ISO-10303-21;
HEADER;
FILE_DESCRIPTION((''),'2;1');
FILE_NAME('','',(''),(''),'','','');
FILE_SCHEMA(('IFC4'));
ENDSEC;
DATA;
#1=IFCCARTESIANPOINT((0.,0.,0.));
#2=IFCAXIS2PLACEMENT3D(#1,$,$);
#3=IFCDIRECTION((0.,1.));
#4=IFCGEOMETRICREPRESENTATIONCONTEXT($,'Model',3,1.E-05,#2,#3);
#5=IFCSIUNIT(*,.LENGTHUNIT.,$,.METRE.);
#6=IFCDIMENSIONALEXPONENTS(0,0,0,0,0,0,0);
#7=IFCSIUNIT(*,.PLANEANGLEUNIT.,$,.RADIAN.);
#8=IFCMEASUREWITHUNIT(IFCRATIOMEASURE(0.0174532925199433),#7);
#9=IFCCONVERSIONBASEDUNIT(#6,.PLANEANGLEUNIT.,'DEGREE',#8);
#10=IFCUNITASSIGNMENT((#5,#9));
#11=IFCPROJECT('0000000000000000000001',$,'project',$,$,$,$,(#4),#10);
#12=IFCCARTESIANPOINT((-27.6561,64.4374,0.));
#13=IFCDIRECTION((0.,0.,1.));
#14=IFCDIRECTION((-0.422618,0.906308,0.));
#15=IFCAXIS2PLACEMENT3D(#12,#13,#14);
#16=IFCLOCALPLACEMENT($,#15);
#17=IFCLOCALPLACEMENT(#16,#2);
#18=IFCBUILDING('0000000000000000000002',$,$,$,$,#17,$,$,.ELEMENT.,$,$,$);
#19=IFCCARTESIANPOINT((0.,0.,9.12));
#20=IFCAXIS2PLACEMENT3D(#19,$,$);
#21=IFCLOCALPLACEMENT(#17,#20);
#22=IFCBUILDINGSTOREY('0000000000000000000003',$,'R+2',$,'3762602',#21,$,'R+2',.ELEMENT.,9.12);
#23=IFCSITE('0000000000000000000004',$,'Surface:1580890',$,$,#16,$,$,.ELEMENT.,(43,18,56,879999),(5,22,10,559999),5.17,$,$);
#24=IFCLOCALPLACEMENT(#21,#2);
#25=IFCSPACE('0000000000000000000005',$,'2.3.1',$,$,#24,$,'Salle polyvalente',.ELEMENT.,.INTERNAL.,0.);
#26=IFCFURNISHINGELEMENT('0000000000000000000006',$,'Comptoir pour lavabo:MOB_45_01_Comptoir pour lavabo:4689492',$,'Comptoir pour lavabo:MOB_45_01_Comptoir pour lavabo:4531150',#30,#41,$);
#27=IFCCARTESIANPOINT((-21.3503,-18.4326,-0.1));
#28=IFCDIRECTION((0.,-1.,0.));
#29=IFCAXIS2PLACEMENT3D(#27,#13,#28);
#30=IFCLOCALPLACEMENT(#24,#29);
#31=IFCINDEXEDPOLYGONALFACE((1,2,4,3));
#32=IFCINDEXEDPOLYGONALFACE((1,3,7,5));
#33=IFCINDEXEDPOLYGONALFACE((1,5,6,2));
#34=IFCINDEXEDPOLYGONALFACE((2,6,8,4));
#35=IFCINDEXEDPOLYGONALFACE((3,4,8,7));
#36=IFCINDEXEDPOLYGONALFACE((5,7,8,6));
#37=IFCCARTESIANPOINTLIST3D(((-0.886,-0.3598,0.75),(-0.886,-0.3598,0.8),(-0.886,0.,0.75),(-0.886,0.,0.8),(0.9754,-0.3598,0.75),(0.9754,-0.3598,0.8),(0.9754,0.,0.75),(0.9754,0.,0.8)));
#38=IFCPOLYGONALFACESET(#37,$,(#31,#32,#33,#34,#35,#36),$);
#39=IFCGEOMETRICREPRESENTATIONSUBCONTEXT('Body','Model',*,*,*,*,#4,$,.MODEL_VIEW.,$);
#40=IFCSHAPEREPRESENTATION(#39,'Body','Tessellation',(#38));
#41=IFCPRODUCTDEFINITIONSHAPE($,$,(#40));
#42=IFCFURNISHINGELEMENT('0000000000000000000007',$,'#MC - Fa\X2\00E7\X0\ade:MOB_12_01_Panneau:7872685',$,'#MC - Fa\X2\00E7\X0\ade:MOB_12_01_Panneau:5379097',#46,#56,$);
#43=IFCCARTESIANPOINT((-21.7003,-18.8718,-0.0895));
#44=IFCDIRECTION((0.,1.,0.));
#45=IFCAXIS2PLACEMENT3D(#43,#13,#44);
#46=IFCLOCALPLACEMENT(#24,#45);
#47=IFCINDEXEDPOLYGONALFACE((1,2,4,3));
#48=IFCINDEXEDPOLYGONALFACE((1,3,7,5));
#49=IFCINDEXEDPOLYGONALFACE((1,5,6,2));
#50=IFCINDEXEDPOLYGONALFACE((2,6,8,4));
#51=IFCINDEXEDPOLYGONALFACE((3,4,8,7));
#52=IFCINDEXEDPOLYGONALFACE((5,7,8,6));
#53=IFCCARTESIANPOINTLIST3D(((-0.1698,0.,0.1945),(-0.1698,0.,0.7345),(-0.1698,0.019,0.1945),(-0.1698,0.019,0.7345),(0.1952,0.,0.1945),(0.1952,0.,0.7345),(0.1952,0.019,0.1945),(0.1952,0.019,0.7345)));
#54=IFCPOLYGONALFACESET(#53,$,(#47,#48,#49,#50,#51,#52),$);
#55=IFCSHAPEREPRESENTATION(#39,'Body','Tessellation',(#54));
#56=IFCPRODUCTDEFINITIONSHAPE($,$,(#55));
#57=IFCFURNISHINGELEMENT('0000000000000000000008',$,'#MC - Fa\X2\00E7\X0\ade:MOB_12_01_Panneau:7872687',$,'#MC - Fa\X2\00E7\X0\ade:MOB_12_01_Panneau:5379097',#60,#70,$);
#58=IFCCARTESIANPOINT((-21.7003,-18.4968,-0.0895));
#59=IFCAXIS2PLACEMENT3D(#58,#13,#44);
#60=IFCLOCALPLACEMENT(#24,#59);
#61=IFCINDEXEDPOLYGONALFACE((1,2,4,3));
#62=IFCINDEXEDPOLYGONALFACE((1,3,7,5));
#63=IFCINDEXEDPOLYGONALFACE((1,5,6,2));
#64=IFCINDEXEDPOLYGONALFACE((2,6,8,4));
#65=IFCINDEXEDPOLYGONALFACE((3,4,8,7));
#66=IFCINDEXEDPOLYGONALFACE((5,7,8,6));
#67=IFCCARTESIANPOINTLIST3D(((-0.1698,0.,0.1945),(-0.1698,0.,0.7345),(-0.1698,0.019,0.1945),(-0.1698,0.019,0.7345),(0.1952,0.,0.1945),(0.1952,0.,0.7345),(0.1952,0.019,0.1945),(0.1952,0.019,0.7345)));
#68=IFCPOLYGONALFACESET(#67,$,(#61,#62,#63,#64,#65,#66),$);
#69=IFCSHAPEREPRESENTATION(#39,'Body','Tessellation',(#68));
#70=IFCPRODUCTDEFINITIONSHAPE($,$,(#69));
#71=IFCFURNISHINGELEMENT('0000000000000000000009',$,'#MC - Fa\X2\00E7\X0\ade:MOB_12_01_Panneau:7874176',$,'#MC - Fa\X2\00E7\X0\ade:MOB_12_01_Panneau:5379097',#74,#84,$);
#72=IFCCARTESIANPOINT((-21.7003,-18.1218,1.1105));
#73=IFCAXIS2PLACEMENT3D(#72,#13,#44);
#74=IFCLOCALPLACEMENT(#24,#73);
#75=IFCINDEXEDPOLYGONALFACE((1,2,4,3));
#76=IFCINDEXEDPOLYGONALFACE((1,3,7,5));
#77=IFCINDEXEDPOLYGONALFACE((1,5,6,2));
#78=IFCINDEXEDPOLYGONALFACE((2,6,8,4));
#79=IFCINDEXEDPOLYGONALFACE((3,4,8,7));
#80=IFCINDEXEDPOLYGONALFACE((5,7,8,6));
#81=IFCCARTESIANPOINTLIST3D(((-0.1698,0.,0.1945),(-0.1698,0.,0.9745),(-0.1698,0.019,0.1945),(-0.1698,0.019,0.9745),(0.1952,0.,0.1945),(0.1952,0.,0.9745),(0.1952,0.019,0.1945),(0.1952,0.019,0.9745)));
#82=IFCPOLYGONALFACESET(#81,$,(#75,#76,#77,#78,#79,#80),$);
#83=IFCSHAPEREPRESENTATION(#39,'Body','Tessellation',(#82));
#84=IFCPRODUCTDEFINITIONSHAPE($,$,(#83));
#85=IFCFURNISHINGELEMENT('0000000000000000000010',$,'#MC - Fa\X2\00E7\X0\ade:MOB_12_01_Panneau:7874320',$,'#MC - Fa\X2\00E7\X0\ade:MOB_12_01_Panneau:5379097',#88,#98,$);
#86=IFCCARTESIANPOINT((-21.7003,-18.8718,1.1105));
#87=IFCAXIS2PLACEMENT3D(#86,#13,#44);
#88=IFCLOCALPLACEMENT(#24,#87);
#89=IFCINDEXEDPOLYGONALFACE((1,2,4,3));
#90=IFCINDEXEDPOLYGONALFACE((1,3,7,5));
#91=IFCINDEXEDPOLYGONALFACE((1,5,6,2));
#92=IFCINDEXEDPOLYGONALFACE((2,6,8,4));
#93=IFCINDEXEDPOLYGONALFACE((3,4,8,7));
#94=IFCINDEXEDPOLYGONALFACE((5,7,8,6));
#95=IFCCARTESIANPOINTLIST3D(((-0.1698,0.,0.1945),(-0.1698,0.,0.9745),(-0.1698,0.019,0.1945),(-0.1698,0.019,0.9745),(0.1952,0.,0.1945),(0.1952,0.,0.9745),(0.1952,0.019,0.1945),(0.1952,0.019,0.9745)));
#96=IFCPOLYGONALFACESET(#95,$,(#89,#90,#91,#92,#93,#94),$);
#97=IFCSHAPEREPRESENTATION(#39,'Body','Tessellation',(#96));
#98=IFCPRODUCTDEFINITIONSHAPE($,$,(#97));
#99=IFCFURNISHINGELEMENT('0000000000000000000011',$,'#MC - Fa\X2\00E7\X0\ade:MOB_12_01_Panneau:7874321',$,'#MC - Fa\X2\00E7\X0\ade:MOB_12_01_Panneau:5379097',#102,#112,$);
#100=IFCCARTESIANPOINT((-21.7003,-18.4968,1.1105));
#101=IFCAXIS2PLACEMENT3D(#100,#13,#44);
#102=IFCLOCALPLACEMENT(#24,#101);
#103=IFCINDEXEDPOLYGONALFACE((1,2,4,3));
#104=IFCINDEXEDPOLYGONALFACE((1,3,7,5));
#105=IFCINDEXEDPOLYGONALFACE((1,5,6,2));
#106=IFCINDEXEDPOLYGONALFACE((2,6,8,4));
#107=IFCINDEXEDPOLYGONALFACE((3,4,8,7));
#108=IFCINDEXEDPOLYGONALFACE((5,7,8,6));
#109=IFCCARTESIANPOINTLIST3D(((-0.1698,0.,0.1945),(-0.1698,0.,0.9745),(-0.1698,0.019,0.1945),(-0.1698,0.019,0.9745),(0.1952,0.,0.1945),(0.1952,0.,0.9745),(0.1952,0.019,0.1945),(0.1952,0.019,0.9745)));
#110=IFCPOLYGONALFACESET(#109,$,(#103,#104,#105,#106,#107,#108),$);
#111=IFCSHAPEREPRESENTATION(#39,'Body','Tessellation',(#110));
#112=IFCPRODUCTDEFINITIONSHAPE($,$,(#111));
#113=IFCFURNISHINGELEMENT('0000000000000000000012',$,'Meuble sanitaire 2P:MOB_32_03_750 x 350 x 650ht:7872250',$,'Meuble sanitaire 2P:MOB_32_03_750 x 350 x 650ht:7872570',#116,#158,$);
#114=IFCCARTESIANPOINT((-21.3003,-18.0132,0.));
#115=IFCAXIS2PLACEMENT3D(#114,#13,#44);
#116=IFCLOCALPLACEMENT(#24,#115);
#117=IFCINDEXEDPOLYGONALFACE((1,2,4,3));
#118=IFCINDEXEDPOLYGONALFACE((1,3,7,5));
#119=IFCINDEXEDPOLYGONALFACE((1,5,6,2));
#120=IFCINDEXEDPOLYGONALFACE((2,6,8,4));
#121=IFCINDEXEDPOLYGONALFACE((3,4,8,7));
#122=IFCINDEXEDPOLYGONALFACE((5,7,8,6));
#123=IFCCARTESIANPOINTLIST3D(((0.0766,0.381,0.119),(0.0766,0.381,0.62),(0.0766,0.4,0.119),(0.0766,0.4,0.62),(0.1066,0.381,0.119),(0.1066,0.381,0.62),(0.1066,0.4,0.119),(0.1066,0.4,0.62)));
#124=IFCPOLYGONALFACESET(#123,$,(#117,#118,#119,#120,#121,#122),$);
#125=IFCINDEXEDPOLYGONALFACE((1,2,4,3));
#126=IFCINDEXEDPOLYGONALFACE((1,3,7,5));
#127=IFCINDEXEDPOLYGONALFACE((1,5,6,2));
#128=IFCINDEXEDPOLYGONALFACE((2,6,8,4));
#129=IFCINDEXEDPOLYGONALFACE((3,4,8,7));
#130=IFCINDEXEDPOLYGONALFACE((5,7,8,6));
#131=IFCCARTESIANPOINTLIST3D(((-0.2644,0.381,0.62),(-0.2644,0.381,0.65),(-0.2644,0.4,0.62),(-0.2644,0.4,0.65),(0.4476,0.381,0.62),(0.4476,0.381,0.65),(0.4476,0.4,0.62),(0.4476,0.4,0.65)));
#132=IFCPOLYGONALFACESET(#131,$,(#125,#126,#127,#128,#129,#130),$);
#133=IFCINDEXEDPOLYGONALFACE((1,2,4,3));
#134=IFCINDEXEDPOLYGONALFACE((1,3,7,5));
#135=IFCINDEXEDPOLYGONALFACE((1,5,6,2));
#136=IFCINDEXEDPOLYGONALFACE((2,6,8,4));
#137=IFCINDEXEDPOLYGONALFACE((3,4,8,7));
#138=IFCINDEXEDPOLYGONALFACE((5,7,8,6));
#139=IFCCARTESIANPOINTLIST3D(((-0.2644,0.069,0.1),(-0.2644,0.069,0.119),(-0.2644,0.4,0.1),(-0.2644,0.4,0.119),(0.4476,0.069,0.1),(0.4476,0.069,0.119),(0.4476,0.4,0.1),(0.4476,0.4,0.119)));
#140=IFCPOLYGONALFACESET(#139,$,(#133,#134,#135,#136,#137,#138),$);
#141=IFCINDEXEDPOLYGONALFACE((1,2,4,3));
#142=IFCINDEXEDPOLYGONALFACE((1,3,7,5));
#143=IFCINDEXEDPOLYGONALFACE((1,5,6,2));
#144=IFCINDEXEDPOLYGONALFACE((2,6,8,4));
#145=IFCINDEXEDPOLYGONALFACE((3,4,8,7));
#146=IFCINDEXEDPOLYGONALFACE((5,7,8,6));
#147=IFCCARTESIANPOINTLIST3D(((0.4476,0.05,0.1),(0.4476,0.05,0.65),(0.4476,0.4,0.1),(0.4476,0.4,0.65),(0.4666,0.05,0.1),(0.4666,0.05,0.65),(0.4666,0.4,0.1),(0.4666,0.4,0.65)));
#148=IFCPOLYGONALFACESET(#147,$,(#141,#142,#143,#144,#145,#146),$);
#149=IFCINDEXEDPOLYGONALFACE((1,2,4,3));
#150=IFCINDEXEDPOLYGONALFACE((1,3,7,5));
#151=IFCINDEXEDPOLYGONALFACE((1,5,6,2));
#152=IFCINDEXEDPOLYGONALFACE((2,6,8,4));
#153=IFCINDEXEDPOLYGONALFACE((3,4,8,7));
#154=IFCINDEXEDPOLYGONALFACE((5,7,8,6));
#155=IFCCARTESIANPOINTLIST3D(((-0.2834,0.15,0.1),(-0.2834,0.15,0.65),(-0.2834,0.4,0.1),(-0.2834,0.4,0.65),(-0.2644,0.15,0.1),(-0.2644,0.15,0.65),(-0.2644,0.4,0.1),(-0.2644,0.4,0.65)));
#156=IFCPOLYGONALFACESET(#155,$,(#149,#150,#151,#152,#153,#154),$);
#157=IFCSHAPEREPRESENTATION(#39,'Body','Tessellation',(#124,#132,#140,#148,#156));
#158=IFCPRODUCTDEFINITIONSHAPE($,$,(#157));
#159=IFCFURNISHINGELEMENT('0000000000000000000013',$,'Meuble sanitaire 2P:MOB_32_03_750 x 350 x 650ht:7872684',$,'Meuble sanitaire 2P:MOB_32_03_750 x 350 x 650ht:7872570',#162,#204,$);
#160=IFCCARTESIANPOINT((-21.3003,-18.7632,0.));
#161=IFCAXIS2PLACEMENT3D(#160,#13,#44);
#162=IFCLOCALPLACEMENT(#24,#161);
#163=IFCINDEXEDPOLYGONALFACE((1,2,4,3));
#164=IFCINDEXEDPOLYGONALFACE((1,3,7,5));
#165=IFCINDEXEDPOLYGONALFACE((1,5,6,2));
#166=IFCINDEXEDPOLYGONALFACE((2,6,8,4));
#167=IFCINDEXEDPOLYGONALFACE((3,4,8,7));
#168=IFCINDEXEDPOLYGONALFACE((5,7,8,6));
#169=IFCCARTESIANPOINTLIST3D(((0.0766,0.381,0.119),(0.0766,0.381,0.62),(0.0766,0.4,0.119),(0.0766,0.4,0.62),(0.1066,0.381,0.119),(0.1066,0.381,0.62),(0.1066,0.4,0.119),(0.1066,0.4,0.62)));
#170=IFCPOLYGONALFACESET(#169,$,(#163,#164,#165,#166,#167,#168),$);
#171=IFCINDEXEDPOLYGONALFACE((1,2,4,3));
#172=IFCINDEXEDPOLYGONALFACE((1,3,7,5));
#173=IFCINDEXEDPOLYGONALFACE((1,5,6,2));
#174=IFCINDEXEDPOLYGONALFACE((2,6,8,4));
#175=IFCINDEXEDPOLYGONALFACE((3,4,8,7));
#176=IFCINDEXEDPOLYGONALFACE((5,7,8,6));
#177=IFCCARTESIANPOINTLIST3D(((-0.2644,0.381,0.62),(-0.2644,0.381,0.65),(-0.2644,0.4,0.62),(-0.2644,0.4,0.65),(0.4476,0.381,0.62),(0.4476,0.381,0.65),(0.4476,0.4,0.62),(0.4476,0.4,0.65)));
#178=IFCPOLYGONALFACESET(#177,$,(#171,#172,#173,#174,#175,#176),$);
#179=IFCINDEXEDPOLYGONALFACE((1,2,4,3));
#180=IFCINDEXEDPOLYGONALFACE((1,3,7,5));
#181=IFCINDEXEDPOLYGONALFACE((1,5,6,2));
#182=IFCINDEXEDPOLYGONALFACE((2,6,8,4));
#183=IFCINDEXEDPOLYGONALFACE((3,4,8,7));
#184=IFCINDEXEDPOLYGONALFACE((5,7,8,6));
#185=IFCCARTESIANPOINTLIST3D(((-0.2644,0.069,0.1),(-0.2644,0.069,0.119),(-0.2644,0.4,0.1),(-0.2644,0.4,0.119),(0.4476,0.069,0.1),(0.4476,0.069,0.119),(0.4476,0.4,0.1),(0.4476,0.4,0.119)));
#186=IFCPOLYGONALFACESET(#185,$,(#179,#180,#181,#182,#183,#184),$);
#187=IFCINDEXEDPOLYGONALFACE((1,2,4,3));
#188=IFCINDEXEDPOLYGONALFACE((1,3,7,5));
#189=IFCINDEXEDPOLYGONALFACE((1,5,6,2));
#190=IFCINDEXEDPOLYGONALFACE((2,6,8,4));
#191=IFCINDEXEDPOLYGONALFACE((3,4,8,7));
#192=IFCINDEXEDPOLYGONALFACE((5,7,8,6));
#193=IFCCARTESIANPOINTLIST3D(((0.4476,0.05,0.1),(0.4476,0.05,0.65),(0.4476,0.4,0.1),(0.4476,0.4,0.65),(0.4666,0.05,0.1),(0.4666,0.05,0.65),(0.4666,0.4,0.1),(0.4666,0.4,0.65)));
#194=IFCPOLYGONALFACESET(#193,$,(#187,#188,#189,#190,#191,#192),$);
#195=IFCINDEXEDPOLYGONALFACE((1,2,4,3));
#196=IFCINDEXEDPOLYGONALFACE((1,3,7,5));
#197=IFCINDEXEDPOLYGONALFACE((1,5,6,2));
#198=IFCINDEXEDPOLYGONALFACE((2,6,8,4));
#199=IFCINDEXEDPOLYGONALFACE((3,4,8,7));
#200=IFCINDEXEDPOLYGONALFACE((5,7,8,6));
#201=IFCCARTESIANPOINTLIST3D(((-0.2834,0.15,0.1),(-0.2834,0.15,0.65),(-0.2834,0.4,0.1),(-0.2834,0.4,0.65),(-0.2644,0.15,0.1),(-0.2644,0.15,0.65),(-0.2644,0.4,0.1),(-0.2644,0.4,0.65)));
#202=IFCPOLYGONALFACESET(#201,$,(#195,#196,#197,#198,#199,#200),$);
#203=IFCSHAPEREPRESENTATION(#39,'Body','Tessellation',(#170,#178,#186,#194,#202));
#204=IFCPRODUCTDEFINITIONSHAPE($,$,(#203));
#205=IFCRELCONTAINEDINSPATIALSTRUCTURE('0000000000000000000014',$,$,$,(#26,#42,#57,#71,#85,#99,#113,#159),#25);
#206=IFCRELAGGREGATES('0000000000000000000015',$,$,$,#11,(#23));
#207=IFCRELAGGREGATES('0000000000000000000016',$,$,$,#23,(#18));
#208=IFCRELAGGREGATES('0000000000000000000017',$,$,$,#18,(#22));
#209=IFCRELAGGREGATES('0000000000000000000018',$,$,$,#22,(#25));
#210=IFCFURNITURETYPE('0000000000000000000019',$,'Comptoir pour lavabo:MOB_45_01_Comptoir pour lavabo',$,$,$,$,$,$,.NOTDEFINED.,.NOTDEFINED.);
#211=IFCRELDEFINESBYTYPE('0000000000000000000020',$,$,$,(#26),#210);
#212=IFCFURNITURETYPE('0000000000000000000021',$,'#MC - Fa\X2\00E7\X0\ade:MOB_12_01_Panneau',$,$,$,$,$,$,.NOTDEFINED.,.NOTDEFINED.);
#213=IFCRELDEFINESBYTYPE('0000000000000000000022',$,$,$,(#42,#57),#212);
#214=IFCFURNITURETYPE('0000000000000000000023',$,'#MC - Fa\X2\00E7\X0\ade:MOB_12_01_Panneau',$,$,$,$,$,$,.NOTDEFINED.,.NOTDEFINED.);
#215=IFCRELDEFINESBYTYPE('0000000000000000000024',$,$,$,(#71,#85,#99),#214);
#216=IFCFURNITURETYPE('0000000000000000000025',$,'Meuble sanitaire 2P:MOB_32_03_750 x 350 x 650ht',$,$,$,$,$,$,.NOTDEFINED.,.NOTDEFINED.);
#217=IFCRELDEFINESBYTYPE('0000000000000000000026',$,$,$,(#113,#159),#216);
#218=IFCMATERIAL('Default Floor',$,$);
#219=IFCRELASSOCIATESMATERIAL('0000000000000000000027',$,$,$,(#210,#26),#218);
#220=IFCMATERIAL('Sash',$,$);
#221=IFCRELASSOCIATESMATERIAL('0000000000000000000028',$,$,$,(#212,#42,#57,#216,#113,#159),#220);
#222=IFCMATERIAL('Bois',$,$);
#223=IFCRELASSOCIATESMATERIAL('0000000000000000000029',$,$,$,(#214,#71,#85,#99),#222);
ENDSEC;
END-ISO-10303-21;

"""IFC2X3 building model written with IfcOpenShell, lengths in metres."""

from ifc_helpers import new_model, entity, si_unit, converted_unit, direction, frame, frame_2d, origin, origin_2d_with_axis, place, context, subcontext, project, spatial, rectangle, extrude, source, transform, mapped, material, type_object, type_shapes, element, save


model = new_model("IFC2X3")

# Units and contexts
model_context = context("Model", 3, precision=1e-05, world=origin(), true_north=direction((0.0, 1.0)))
body_context = subcontext(model_context, "Body", "Model", "MODEL_VIEW")
ifc_project = project(units=[si_unit("LENGTHUNIT", "METRE"), converted_unit("PLANEANGLEUNIT", "DEGREE", entity("IfcRatioMeasure", 0.0174532925199433), si_unit("PLANEANGLEUNIT", "RADIAN"), dimensions=[0, 0, 0, 0, 0, 0, 0])], contexts=[model_context])

# Site, building, storey
site_placement = place(None, frame((-27.6561, 64.4374, 0.0), z_axis=(0.0, 0.0, 1.0), x_axis=(-0.422618, 0.906308, 0.0)))
site = spatial("IfcSite", under=ifc_project, at=site_placement, Name="Surface:1580890", CompositionType="ELEMENT", RefLatitude=(43, 18, 56, 879999), RefLongitude=(5, 22, 10, 559999), RefElevation=5.17)
building_placement = place(site_placement, origin())
building = spatial("IfcBuilding", under=site, at=building_placement, CompositionType="ELEMENT")
storey_placement = place(building_placement, frame((0.0, 0.0, 9.12)))
storey = spatial("IfcBuildingStorey", under=building, at=storey_placement, Name="R+2", ObjectType="3762602", LongName="R+2", CompositionType="ELEMENT", Elevation=9.12)

# Shared definitions
space_placement = place(storey_placement, origin())
space = spatial("IfcSpace", under=storey, at=space_placement, Name="2.3.1", LongName="Salle polyvalente", CompositionType="ELEMENT", InteriorOrExteriorSpace="INTERNAL", ElevationWithFlooring=0.0)

# Furnishing elements
ifc_material_1 = material(Name="Default Floor")
furniture_type_1 = type_object("IfcFurnitureType", Name="Comptoir pour lavabo:MOB_45_01_Comptoir pour lavabo", material=ifc_material_1)
shared_shape_1 = source(origin(), body_context, "Body", "SweptSolid", [
    extrude(rectangle(XDim=1.8614, YDim=0.3598, at=origin_2d_with_axis()), frame((0.0447, -0.1799, 0.75), z_axis=(0.0, 0.0, 1.0), x_axis=(-1.0, 0.0, 0.0)), (0.0, 0.0, 1.0), 0.05),
])
type_shapes(furniture_type_1, [shared_shape_1])
furnishing_1_placement = place(space_placement, frame((-21.3503, -18.4326, -0.1), z_axis=(0.0, 0.0, 1.0), x_axis=(0.0, -1.0, 0.0)))
element("IfcFurnishingElement", 1, at=furnishing_1_placement, inside=space, type_object=furniture_type_1, material=ifc_material_1, Name="Comptoir pour lavabo:MOB_45_01_Comptoir pour lavabo:4689492", ObjectType="Comptoir pour lavabo:MOB_45_01_Comptoir pour lavabo:4531150", context=body_context, shape_type="MappedRepresentation", body=[
    mapped(shared_shape_1, transform((0.0, 0.0, 0.0), scale=1.0)),
])
ifc_material_2 = material(Name="Sash")
furniture_type_2 = type_object("IfcFurnitureType", Name="#MC - Façade:MOB_12_01_Panneau", material=ifc_material_2)
shared_shape_2 = source(origin(), body_context, "Body", "SweptSolid", [
    extrude(rectangle(XDim=0.019, YDim=0.365, at=origin_2d_with_axis()), frame((0.0127, 0.0095, 0.1945), z_axis=(0.0, 0.0, 1.0), x_axis=(0.0, 1.0, 0.0)), (0.0, 0.0, 1.0), 0.54),
])
type_shapes(furniture_type_2, [shared_shape_2])
for number, where, z_axis, x_axis, name in (
    (2, (-21.7003, -18.8718, -0.0895), (0.0, 0.0, 1.0), (0.0, 1.0, 0.0), "#MC - Façade:MOB_12_01_Panneau:7872685"),
    (3, (-21.7003, -18.4968, -0.0895), (0.0, 0.0, 1.0), (0.0, 1.0, 0.0), "#MC - Façade:MOB_12_01_Panneau:7872687"),
):
    element("IfcFurnishingElement", number, at=place(space_placement, frame(where, z_axis=z_axis, x_axis=x_axis)), inside=space, type_object=furniture_type_2, material=ifc_material_2, Name=name, ObjectType="#MC - Façade:MOB_12_01_Panneau:5379097", context=body_context, shape_type="MappedRepresentation", body=[
        mapped(shared_shape_2, transform((0.0, 0.0, 0.0), scale=1.0)),
    ])
ifc_material_3 = material(Name="Bois")
furniture_type_3 = type_object("IfcFurnitureType", Name="#MC - Façade:MOB_12_01_Panneau", material=ifc_material_3)
shared_shape_3 = source(origin(), body_context, "Body", "SweptSolid", [
    extrude(rectangle(XDim=0.019, YDim=0.365, at=origin_2d_with_axis()), frame((0.0127, 0.0095, 0.1945), z_axis=(0.0, 0.0, 1.0), x_axis=(0.0, 1.0, 0.0)), (0.0, 0.0, 1.0), 0.78),
])
type_shapes(furniture_type_3, [shared_shape_3])
for number, where, z_axis, x_axis, name in (
    (4, (-21.7003, -18.1218, 1.1105), (0.0, 0.0, 1.0), (0.0, 1.0, 0.0), "#MC - Façade:MOB_12_01_Panneau:7874176"),
    (5, (-21.7003, -18.8718, 1.1105), (0.0, 0.0, 1.0), (0.0, 1.0, 0.0), "#MC - Façade:MOB_12_01_Panneau:7874320"),
    (6, (-21.7003, -18.4968, 1.1105), (0.0, 0.0, 1.0), (0.0, 1.0, 0.0), "#MC - Façade:MOB_12_01_Panneau:7874321"),
):
    element("IfcFurnishingElement", number, at=place(space_placement, frame(where, z_axis=z_axis, x_axis=x_axis)), inside=space, type_object=furniture_type_3, material=ifc_material_3, Name=name, ObjectType="#MC - Façade:MOB_12_01_Panneau:5379097", context=body_context, shape_type="MappedRepresentation", body=[
        mapped(shared_shape_3, transform((0.0, 0.0, 0.0), scale=1.0)),
    ])
furniture_type_4 = type_object("IfcFurnitureType", Name="Meuble sanitaire 2P:MOB_32_03_750 x 350 x 650ht", material=ifc_material_2)
shared_shape_4 = source(origin(), body_context, "Body", "SweptSolid", [
    extrude(rectangle(XDim=0.019, YDim=0.03, at=frame_2d((0.0, 0.0), x_axis=(1.0, 0.0))), frame((0.0916, 0.3905, 0.119), z_axis=(0.0, 0.0, 1.0), x_axis=(0.0, 1.0, 0.0)), (0.0, 0.0, 1.0), 0.501),
    extrude(rectangle(XDim=0.019, YDim=0.712, at=origin_2d_with_axis()), frame((0.0916, 0.3905, 0.62), z_axis=(0.0, 0.0, 1.0), x_axis=(0.0, 1.0, 0.0)), (0.0, 0.0, 1.0), 0.03),
    extrude(rectangle(XDim=0.712, YDim=0.331, at=origin_2d_with_axis()), frame((0.0916, 0.2345, 0.1), z_axis=(0.0, 0.0, 1.0), x_axis=(-1.0, 0.0, 0.0)), (0.0, 0.0, 1.0), 0.019),
    extrude(rectangle(XDim=0.019, YDim=0.35, at=origin_2d_with_axis()), frame((0.4571, 0.225, 0.1), z_axis=(0.0, 0.0, 1.0), x_axis=(-1.0, 0.0, 0.0)), (0.0, 0.0, 1.0), 0.55),
    extrude(rectangle(XDim=0.019, YDim=0.25, at=origin_2d_with_axis()), frame((-0.2739, 0.275, 0.1), z_axis=(0.0, 0.0, 1.0), x_axis=(-1.0, 0.0, 0.0)), (0.0, 0.0, 1.0), 0.55),
])
type_shapes(furniture_type_4, [shared_shape_4])
for number, where, z_axis, x_axis, name in (
    (7, (-21.3003, -18.0132, 0.0), (0.0, 0.0, 1.0), (0.0, 1.0, 0.0), "Meuble sanitaire 2P:MOB_32_03_750 x 350 x 650ht:7872250"),
    (8, (-21.3003, -18.7632, 0.0), (0.0, 0.0, 1.0), (0.0, 1.0, 0.0), "Meuble sanitaire 2P:MOB_32_03_750 x 350 x 650ht:7872684"),
):
    element("IfcFurnishingElement", number, at=place(space_placement, frame(where, z_axis=z_axis, x_axis=x_axis)), inside=space, type_object=furniture_type_4, material=ifc_material_2, Name=name, ObjectType="Meuble sanitaire 2P:MOB_32_03_750 x 350 x 650ht:7872570", context=body_context, shape_type="MappedRepresentation", body=[
        mapped(shared_shape_4, transform((0.0, 0.0, 0.0), scale=1.0)),
    ])

save(model, "model.ifc")
